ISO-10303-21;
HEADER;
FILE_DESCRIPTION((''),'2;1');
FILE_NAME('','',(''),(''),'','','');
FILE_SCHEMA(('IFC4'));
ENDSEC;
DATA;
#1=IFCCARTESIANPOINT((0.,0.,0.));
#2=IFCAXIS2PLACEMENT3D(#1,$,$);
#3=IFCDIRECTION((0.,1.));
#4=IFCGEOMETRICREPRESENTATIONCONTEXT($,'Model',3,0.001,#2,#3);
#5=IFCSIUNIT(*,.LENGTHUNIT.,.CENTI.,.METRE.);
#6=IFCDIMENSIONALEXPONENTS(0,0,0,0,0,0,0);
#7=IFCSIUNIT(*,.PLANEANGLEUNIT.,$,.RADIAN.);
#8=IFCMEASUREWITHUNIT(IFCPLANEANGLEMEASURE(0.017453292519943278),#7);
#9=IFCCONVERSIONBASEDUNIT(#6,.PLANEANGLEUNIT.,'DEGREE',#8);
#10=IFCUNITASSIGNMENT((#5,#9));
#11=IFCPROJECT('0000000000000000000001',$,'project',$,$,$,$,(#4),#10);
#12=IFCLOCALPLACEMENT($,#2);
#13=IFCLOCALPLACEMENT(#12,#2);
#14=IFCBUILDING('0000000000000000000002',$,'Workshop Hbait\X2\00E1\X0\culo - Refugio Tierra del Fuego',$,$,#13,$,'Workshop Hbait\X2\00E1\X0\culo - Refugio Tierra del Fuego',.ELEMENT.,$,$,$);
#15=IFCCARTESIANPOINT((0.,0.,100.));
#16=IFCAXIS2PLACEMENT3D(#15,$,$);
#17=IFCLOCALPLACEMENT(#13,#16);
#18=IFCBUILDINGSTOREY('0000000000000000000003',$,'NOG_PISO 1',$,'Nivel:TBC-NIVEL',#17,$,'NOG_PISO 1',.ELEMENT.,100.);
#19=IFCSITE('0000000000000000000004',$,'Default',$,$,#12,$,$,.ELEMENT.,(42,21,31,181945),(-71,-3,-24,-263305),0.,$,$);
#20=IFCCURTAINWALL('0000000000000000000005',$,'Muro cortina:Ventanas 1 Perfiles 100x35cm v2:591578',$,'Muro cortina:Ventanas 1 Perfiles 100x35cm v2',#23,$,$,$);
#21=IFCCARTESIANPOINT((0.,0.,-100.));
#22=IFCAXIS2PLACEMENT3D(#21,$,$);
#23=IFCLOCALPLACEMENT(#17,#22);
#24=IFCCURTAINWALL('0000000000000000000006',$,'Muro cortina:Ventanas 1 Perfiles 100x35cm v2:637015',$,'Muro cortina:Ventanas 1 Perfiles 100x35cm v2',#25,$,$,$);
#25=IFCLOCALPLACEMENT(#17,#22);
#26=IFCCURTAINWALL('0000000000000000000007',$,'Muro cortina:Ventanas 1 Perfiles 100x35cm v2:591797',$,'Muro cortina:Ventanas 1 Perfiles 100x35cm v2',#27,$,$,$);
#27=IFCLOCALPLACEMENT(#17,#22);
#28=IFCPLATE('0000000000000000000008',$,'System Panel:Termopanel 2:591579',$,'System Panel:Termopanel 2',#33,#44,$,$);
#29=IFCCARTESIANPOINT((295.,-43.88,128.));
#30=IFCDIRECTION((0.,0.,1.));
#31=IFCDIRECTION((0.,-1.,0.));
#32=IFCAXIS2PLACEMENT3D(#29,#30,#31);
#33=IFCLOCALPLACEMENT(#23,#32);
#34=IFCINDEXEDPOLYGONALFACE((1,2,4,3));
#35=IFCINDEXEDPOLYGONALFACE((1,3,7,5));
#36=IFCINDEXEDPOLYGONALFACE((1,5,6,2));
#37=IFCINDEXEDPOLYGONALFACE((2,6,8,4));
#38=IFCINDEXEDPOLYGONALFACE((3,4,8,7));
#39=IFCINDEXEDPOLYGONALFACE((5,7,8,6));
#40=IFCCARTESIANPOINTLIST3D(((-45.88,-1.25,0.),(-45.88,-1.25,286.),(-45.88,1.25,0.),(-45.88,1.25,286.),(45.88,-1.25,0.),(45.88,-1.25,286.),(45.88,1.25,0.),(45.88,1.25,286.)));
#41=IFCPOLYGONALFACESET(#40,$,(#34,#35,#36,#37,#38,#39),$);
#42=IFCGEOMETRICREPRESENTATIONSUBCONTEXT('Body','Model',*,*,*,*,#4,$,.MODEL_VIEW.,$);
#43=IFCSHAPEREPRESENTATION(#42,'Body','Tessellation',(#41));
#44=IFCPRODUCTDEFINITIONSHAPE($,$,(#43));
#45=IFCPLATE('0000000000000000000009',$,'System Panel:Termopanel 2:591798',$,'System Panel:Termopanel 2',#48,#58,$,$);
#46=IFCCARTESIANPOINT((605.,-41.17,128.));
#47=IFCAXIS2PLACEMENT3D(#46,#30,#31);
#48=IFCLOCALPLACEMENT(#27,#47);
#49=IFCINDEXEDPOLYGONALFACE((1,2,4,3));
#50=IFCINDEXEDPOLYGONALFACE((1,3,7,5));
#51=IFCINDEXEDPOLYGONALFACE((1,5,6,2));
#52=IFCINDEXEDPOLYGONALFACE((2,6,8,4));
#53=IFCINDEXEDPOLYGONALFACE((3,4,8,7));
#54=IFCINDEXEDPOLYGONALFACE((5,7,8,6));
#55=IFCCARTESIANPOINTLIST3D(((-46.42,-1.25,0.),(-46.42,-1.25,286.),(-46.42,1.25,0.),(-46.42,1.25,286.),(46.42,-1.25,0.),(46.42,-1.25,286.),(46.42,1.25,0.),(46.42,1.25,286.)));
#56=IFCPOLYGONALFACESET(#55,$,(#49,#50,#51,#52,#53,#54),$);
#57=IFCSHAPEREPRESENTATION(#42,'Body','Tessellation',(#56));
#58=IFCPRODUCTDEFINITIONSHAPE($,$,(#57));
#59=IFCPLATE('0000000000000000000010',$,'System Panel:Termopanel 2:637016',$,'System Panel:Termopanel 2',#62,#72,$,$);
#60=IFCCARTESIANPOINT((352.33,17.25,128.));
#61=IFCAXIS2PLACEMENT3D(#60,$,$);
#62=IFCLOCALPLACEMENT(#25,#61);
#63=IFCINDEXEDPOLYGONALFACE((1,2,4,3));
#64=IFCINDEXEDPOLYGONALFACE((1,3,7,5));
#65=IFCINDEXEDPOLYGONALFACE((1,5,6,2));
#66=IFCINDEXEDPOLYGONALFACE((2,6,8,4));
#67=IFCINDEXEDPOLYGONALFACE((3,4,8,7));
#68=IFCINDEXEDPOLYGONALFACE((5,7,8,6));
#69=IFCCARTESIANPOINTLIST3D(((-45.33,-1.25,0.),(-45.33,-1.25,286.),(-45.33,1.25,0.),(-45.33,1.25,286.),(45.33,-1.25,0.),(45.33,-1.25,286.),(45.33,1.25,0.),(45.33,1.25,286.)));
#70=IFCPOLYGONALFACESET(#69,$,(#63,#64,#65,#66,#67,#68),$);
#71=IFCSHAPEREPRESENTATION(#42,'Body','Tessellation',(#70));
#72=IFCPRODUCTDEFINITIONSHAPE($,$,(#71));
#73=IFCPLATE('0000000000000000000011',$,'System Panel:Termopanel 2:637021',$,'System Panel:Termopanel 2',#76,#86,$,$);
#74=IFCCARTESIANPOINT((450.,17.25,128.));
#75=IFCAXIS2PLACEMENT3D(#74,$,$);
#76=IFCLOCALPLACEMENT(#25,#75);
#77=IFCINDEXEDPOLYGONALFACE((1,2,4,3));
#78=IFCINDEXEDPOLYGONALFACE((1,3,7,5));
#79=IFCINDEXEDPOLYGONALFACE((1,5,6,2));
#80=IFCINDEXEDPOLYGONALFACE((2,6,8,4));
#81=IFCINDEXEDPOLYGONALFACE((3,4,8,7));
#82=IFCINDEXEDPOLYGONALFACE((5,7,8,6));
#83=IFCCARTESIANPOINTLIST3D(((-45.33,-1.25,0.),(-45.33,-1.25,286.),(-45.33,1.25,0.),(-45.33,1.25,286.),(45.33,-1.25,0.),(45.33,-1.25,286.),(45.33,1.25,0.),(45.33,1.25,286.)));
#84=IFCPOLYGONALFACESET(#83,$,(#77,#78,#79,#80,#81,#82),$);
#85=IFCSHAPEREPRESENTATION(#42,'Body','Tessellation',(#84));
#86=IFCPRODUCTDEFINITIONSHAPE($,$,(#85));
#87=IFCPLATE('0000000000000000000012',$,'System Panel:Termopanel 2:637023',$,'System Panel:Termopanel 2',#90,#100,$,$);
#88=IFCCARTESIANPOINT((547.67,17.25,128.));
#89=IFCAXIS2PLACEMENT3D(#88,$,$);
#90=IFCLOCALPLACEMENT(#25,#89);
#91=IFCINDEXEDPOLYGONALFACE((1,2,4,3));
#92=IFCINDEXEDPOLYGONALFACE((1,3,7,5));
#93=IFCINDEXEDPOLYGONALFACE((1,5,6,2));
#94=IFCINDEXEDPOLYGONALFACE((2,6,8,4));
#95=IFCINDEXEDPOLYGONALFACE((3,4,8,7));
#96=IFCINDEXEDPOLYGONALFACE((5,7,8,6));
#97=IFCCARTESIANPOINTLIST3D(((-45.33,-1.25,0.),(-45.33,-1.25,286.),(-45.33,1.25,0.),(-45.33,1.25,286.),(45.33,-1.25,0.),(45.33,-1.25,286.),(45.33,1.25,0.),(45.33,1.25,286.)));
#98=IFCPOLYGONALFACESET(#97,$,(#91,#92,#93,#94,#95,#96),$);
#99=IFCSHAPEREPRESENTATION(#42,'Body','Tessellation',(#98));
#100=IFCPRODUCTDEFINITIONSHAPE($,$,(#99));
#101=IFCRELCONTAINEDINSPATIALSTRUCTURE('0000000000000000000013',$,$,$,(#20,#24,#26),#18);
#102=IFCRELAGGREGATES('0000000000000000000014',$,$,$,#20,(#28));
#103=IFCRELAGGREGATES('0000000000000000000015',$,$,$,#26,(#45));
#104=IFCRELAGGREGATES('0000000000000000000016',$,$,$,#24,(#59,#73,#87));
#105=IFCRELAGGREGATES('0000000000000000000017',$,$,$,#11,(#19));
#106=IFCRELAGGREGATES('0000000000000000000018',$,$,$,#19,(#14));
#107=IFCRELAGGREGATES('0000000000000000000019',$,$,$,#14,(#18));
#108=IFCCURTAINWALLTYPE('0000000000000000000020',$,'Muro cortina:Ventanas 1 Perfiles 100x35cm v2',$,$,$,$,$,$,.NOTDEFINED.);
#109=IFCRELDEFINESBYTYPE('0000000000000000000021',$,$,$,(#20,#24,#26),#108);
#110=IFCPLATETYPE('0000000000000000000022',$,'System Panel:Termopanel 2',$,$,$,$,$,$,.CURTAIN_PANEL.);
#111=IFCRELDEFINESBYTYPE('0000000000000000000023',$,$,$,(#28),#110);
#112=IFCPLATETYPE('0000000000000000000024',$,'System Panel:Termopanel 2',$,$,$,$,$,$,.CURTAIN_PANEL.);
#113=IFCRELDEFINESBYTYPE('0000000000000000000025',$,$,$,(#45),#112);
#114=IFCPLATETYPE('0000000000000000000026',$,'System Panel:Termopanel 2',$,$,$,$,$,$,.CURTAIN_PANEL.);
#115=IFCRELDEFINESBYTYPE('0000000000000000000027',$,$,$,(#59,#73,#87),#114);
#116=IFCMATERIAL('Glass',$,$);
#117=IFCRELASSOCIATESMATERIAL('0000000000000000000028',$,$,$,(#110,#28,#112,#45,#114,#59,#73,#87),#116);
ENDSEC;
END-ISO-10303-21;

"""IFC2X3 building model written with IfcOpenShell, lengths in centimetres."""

from ifc_helpers import new_model, entity, si_unit, converted_unit, direction, frame, frame_2d, origin, origin_2d_with_axis, place, context, subcontext, project, spatial, rectangle, extrude, source, transform, mapped, material, type_object, type_shapes, element, aggregate, save


model = new_model("IFC2X3")

# Units and contexts
model_context = context("Model", 3, precision=0.001, world=origin(), true_north=direction((0.0, 1.0)))
body_context = subcontext(model_context, "Body", "Model", "MODEL_VIEW")
ifc_project = project(units=[si_unit("LENGTHUNIT", "METRE", prefix="CENTI"), converted_unit("PLANEANGLEUNIT", "DEGREE", entity("IfcPlaneAngleMeasure", 0.017453292519943278), si_unit("PLANEANGLEUNIT", "RADIAN"), dimensions=[0, 0, 0, 0, 0, 0, 0])], contexts=[model_context])

# Site, building, storey
site_placement = place(None, origin())
site = spatial("IfcSite", under=ifc_project, at=site_placement, Name="Default", CompositionType="ELEMENT", RefLatitude=(42, 21, 31, 181945), RefLongitude=(-71, -3, -24, -263305), RefElevation=0.0)
building_placement = place(site_placement, origin())
building = spatial("IfcBuilding", under=site, at=building_placement, Name="Workshop Hbaitáculo - Refugio Tierra del Fuego", LongName="Workshop Hbaitáculo - Refugio Tierra del Fuego", CompositionType="ELEMENT")
storey_placement = place(building_placement, frame((0.0, 0.0, 100.0)))
storey = spatial("IfcBuildingStorey", under=building, at=storey_placement, Name="NOG_PISO 1", ObjectType="Nivel:TBC-NIVEL", LongName="NOG_PISO 1", CompositionType="ELEMENT", Elevation=100.0)

# Curtain walls
curtain_wall_type = type_object("IfcCurtainWallType", Name="Muro cortina:Ventanas 1 Perfiles 100x35cm v2", PredefinedType="NOTDEFINED")
curtain_wall_1_placement = place(storey_placement, frame((0.0, 0.0, -100.0)))
curtain_wall_1 = element("IfcCurtainWall", 1, at=curtain_wall_1_placement, inside=storey, type_object=curtain_wall_type, Name="Muro cortina:Ventanas 1 Perfiles 100x35cm v2:591578", ObjectType="Muro cortina:Ventanas 1 Perfiles 100x35cm v2")
curtain_wall_2_placement = place(storey_placement, frame((0.0, 0.0, -100.0)))
curtain_wall_2 = element("IfcCurtainWall", 2, at=curtain_wall_2_placement, inside=storey, type_object=curtain_wall_type, Name="Muro cortina:Ventanas 1 Perfiles 100x35cm v2:637015", ObjectType="Muro cortina:Ventanas 1 Perfiles 100x35cm v2")

# Curtain wall
curtain_wall_3_placement = place(storey_placement, frame((0.0, 0.0, -100.0)))
curtain_wall_3 = element("IfcCurtainWall", 3, at=curtain_wall_3_placement, inside=storey, type_object=curtain_wall_type, Name="Muro cortina:Ventanas 1 Perfiles 100x35cm v2:591797", ObjectType="Muro cortina:Ventanas 1 Perfiles 100x35cm v2")

# Plates
ifc_material_1 = material(Name="Glass")
plate_type_1 = type_object("IfcPlateType", Name="System Panel:Termopanel 2", PredefinedType="CURTAIN_PANEL", material=ifc_material_1)
shared_shape_1 = source(origin(), body_context, "Body", "SweptSolid", [
    extrude(rectangle(XDim=2.5, YDim=91.75, at=frame_2d((0.0, 0.0), x_axis=(1.0, 0.0))), frame((0.0, 0.0, 0.0), z_axis=(0.0, 0.0, 1.0), x_axis=(0.0, 1.0, 0.0)), (0.0, 0.0, 1.0), 286.0),
])
type_shapes(plate_type_1, [shared_shape_1])
plate_1_placement = place(curtain_wall_1_placement, frame((295.0, -43.88, 128.0), z_axis=(0.0, 0.0, 1.0), x_axis=(0.0, -1.0, 0.0)))
plate_1 = element("IfcPlate", 4, at=plate_1_placement, type_object=plate_type_1, material=ifc_material_1, Name="System Panel:Termopanel 2:591579", ObjectType="System Panel:Termopanel 2", context=body_context, shape_type="MappedRepresentation", body=[
    mapped(shared_shape_1, transform((0.0, 0.0, 0.0), scale=1.0)),
])
aggregate(curtain_wall_1, [plate_1])
plate_type_2 = type_object("IfcPlateType", Name="System Panel:Termopanel 2", PredefinedType="CURTAIN_PANEL", material=ifc_material_1)
shared_shape_2 = source(origin(), body_context, "Body", "SweptSolid", [
    extrude(rectangle(XDim=2.5, YDim=92.83, at=origin_2d_with_axis()), frame((0.0, 0.0, 0.0), z_axis=(0.0, 0.0, 1.0), x_axis=(0.0, 1.0, 0.0)), (0.0, 0.0, 1.0), 286.0),
])
type_shapes(plate_type_2, [shared_shape_2])
plate_2_placement = place(curtain_wall_3_placement, frame((605.0, -41.17, 128.0), z_axis=(0.0, 0.0, 1.0), x_axis=(0.0, -1.0, 0.0)))
plate_2 = element("IfcPlate", 5, at=plate_2_placement, type_object=plate_type_2, material=ifc_material_1, Name="System Panel:Termopanel 2:591798", ObjectType="System Panel:Termopanel 2", context=body_context, shape_type="MappedRepresentation", body=[
    mapped(shared_shape_2, transform((0.0, 0.0, 0.0), scale=1.0)),
])
aggregate(curtain_wall_3, [plate_2])
plate_type_3 = type_object("IfcPlateType", Name="System Panel:Termopanel 2", PredefinedType="CURTAIN_PANEL", material=ifc_material_1)
shared_shape_3 = source(origin(), body_context, "Body", "SweptSolid", [
    extrude(rectangle(XDim=2.5, YDim=90.67, at=origin_2d_with_axis()), frame((0.0, 0.0, 0.0), z_axis=(0.0, 0.0, 1.0), x_axis=(0.0, 1.0, 0.0)), (0.0, 0.0, 1.0), 286.0),
])
type_shapes(plate_type_3, [shared_shape_3])
plate_3_placement = place(curtain_wall_2_placement, frame((352.33, 17.25, 128.0)))
plate_3 = element("IfcPlate", 6, at=plate_3_placement, type_object=plate_type_3, material=ifc_material_1, Name="System Panel:Termopanel 2:637016", ObjectType="System Panel:Termopanel 2", context=body_context, shape_type="MappedRepresentation", body=[
    mapped(shared_shape_3, transform((0.0, 0.0, 0.0), scale=1.0)),
])
plate_4_placement = place(curtain_wall_2_placement, frame((450.0, 17.25, 128.0)))
plate_4 = element("IfcPlate", 7, at=plate_4_placement, type_object=plate_type_3, material=ifc_material_1, Name="System Panel:Termopanel 2:637021", ObjectType="System Panel:Termopanel 2", context=body_context, shape_type="MappedRepresentation", body=[
    mapped(shared_shape_3, transform((0.0, 0.0, 0.0), scale=1.0)),
])
plate_5_placement = place(curtain_wall_2_placement, frame((547.67, 17.25, 128.0)))
plate_5 = element("IfcPlate", 8, at=plate_5_placement, type_object=plate_type_3, material=ifc_material_1, Name="System Panel:Termopanel 2:637023", ObjectType="System Panel:Termopanel 2", context=body_context, shape_type="MappedRepresentation", body=[
    mapped(shared_shape_3, transform((0.0, 0.0, 0.0), scale=1.0)),
])
aggregate(curtain_wall_2, [plate_3, plate_4, plate_5])

save(model, "model.ifc")
